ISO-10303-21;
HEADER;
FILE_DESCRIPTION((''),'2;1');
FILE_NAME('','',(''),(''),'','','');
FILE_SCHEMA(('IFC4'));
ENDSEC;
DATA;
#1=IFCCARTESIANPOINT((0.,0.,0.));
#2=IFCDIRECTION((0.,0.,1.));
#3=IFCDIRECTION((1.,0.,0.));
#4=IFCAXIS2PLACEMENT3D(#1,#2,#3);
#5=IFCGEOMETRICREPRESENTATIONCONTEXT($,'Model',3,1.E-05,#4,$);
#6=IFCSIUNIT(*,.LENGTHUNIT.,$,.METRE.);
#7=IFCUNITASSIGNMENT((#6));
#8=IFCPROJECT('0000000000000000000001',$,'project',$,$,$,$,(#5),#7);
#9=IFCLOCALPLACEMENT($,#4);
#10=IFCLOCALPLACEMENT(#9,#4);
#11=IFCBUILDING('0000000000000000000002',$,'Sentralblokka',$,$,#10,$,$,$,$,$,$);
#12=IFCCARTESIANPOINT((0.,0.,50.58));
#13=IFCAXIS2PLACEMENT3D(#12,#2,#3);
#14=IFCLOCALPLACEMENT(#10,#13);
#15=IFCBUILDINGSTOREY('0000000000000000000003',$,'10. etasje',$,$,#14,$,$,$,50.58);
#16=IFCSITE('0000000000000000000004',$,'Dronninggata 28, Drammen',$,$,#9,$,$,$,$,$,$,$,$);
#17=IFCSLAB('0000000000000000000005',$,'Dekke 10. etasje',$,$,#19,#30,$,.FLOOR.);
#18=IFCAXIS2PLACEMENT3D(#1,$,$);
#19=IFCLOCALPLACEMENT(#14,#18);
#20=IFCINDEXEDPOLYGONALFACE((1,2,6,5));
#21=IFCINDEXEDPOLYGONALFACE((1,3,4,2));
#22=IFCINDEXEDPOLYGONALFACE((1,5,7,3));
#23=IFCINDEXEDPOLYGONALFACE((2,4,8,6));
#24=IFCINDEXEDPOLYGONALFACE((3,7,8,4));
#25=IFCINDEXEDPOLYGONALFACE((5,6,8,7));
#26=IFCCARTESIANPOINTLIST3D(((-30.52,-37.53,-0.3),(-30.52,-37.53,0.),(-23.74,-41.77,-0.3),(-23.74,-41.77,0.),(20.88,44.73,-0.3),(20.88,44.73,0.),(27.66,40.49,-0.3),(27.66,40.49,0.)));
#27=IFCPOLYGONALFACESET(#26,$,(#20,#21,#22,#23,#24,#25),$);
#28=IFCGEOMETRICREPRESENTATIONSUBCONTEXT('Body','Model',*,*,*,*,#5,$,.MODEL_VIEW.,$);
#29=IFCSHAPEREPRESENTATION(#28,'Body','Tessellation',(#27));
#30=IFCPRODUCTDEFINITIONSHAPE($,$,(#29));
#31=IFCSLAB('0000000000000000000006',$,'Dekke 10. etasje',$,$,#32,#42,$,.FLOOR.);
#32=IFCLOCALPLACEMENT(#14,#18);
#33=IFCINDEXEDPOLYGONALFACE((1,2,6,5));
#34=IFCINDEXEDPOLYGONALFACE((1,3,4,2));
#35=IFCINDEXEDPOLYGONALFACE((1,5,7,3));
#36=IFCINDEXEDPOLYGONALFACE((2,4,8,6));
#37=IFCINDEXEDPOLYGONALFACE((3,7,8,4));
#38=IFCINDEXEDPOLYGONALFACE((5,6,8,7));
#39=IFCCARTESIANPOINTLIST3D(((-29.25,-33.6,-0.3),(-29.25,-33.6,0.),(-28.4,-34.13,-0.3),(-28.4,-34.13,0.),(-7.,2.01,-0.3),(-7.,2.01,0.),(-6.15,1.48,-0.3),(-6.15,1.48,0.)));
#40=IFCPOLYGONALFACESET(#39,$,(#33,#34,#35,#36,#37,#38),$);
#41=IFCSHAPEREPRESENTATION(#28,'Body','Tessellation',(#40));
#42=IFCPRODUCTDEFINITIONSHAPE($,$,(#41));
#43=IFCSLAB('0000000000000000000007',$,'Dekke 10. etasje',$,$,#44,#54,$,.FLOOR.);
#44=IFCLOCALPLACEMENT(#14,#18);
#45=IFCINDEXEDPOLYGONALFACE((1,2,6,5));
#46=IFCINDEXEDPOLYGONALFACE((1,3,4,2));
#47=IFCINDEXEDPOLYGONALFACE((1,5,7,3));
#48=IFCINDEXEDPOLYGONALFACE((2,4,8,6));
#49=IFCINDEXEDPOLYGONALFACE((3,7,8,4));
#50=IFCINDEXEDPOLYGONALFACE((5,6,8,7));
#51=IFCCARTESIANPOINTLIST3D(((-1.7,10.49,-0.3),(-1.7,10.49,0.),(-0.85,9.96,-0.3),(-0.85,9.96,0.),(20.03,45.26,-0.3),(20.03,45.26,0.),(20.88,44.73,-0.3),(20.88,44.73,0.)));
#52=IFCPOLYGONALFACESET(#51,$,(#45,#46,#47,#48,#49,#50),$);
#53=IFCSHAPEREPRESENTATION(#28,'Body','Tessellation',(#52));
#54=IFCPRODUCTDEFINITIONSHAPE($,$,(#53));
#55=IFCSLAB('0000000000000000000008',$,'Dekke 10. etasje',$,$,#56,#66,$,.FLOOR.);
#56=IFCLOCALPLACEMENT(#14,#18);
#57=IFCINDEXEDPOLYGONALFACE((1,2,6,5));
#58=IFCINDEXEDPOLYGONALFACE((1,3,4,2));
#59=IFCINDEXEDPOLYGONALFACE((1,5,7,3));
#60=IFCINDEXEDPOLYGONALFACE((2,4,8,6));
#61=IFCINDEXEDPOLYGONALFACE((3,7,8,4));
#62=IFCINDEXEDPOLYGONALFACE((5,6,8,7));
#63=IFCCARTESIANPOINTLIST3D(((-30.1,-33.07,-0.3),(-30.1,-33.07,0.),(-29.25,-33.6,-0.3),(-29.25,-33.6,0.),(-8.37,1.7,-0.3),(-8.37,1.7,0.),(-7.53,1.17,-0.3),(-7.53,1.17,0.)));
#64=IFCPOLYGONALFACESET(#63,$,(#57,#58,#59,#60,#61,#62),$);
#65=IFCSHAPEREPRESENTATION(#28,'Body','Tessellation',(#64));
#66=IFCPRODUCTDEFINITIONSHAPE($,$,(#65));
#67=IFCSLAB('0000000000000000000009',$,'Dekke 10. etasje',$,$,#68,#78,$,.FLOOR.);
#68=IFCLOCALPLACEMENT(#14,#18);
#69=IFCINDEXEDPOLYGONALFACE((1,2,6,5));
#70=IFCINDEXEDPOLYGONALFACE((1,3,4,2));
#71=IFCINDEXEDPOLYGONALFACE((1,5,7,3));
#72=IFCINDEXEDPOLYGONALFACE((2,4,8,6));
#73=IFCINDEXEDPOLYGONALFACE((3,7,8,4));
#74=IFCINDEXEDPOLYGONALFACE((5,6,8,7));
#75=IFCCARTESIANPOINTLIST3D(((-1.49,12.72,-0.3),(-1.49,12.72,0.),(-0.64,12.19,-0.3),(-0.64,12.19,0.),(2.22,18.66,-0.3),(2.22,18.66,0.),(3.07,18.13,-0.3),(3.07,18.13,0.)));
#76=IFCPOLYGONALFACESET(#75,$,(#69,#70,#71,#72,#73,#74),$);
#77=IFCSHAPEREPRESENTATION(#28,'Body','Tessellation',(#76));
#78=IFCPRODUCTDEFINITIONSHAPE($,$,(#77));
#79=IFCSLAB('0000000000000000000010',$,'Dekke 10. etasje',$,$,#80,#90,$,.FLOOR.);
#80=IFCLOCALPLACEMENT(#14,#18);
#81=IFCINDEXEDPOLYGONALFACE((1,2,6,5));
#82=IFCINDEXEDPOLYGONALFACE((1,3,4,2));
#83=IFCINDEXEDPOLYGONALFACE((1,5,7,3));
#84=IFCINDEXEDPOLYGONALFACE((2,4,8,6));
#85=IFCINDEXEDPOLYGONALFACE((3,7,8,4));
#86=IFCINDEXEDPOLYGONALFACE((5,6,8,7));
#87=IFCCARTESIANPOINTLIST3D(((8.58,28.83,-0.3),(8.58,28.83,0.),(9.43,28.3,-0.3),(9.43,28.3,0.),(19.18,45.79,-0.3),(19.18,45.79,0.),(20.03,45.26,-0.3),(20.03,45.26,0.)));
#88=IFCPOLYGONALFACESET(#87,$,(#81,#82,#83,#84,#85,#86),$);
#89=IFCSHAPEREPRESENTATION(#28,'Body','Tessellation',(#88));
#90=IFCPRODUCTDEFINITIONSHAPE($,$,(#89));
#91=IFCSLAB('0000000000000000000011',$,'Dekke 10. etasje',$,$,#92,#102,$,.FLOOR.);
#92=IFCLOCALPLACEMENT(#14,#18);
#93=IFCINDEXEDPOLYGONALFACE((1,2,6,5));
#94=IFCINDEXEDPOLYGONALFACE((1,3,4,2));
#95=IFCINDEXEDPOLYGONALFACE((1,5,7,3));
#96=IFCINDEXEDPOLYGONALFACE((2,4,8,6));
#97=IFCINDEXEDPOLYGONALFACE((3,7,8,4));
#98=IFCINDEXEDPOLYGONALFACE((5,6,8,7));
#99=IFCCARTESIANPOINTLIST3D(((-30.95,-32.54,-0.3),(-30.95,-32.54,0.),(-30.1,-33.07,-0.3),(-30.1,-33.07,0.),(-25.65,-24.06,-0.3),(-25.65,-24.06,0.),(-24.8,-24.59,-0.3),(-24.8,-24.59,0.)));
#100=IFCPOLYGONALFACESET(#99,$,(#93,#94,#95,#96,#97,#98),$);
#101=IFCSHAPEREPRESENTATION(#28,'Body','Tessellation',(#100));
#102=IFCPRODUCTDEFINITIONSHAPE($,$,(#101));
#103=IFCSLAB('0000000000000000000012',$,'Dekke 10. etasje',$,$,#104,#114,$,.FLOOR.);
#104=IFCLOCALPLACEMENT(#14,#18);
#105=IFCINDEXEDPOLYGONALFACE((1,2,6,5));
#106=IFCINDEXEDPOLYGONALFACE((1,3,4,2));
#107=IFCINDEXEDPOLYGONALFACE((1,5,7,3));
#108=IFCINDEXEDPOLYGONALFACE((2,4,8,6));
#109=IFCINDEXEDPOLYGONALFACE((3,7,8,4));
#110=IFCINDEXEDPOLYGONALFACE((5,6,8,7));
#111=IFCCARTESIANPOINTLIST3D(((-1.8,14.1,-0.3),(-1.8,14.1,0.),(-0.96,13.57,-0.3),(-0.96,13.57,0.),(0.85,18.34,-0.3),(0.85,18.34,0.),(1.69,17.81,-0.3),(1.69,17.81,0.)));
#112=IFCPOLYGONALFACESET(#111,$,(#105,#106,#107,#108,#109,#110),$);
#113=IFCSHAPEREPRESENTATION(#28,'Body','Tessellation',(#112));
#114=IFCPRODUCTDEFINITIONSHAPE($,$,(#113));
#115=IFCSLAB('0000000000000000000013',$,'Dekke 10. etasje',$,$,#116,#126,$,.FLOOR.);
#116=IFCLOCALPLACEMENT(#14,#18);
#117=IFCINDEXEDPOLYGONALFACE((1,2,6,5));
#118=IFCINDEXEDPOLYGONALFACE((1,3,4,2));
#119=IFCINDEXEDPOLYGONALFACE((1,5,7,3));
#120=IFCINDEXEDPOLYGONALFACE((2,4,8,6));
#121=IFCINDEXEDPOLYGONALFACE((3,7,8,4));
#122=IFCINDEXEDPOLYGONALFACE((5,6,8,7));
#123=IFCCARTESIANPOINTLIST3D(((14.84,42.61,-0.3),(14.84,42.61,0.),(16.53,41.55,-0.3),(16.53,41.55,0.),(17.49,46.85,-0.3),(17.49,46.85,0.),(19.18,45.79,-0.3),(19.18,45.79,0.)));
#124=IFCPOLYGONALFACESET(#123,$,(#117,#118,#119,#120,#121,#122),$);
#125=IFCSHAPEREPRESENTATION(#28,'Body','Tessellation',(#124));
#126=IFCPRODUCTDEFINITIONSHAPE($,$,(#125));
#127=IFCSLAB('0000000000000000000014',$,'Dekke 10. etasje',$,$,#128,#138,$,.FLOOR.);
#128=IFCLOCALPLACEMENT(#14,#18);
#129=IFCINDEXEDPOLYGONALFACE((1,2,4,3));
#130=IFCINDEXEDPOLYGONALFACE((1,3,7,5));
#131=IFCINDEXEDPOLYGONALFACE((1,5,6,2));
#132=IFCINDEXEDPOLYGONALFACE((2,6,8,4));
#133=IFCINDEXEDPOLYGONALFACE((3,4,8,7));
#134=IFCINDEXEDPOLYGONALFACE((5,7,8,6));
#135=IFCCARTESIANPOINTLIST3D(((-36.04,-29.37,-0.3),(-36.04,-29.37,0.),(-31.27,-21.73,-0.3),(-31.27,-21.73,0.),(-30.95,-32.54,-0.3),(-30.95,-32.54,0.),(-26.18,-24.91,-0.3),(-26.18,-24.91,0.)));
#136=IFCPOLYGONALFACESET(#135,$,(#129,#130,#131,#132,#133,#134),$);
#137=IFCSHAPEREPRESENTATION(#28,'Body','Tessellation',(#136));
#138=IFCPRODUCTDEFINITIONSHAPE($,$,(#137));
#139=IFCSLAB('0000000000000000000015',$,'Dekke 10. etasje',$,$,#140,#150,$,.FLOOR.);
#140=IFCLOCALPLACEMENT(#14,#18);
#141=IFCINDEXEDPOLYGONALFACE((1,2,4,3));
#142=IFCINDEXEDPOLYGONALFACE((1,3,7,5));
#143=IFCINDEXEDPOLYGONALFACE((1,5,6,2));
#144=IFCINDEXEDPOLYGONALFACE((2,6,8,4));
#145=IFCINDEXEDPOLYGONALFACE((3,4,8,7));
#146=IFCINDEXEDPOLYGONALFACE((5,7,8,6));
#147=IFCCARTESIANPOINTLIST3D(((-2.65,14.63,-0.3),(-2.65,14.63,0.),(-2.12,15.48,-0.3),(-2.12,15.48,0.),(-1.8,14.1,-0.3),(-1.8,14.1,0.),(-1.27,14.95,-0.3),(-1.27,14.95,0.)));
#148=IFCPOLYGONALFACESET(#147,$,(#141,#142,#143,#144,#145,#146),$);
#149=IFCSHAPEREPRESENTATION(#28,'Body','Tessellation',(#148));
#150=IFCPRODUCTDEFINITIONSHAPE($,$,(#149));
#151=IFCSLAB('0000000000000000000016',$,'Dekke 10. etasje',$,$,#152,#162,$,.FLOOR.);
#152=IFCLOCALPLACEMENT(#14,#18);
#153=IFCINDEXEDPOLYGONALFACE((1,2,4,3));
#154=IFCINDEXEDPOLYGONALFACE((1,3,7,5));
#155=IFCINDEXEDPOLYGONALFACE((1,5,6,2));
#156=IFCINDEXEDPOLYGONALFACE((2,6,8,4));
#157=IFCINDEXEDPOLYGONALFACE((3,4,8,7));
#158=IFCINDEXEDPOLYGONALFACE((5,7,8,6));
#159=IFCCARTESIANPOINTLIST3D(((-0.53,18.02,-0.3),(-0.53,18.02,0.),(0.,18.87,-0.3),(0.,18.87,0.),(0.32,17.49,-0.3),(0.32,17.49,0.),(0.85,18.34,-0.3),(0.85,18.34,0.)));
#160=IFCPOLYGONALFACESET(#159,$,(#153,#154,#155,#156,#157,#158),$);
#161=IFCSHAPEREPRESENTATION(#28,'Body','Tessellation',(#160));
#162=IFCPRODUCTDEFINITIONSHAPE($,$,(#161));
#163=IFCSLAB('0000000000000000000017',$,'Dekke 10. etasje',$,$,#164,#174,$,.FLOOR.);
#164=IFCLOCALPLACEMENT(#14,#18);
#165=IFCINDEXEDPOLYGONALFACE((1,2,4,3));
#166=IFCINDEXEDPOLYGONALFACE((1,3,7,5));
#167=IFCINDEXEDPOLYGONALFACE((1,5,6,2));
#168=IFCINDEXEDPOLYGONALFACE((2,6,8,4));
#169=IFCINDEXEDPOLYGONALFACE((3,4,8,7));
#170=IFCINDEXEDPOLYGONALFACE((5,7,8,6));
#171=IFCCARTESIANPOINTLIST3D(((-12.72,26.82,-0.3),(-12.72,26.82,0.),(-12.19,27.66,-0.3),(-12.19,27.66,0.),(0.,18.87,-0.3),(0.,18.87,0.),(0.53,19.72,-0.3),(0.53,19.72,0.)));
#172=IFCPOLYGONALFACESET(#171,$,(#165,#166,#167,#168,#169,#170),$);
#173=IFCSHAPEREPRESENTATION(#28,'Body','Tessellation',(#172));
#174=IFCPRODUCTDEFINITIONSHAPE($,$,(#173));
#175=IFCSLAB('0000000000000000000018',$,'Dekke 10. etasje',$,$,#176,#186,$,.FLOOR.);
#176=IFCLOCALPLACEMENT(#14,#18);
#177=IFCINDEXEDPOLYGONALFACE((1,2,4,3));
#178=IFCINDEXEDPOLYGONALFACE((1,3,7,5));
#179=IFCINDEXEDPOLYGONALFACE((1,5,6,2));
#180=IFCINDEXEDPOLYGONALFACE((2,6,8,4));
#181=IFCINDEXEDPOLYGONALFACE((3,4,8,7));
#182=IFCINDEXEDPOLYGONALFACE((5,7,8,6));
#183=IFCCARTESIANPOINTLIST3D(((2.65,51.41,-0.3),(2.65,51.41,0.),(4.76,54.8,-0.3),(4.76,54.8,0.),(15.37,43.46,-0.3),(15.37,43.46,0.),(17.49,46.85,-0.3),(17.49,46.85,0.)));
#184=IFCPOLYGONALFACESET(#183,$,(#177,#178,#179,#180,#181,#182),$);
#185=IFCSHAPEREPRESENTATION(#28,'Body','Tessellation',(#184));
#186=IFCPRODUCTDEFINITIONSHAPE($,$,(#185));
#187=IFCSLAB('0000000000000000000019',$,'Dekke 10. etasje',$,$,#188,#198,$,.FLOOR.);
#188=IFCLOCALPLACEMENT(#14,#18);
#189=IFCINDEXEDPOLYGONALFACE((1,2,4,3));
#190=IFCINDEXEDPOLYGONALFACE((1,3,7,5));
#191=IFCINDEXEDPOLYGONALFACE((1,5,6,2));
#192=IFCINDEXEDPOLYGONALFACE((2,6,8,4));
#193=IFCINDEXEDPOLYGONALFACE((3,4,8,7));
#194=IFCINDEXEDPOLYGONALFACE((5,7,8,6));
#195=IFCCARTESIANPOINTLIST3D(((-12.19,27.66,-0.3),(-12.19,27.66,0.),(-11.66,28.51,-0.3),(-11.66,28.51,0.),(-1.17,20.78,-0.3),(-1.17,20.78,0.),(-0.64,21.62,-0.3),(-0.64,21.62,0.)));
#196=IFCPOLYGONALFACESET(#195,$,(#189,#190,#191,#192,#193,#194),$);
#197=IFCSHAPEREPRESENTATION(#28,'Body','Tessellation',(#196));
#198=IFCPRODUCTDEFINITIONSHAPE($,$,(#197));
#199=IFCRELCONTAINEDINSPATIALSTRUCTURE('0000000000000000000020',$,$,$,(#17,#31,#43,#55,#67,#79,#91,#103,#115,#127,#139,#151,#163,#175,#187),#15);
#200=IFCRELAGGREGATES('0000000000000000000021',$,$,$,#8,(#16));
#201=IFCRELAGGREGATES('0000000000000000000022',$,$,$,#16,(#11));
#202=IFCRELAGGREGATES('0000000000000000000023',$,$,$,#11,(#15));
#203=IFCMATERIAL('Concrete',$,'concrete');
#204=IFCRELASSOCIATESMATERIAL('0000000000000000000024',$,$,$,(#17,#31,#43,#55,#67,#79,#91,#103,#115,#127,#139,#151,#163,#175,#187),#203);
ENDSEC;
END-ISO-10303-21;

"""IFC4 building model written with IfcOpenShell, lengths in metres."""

from ifc_helpers import new_model, si_unit, frame, origin_with_axes, place, context, subcontext, project, spatial, polyline, outline, extrude, material, element, save


model = new_model("IFC4")

# Units and contexts
model_context = context("Model", 3, precision=1e-05, world=origin_with_axes())
body_context = subcontext(model_context, "Body", "Model", "MODEL_VIEW")
ifc_project = project(units=[si_unit("LENGTHUNIT", "METRE")], contexts=[model_context])

# Site, building, storey
site_placement = place(None, origin_with_axes())
site = spatial("IfcSite", under=ifc_project, at=site_placement, Name="Dronninggata 28, Drammen")
building_placement = place(site_placement, origin_with_axes())
building = spatial("IfcBuilding", under=site, at=building_placement, Name="Sentralblokka")
storey_placement = place(building_placement, frame((0.0, 0.0, 50.58), z_axis=(0.0, 0.0, 1.0), x_axis=(1.0, 0.0, 0.0)))
storey = spatial("IfcBuildingStorey", under=building, at=storey_placement, Name="10. etasje", Elevation=50.58)

# Slabs
ifc_material = material(Name="Concrete", Category="concrete")
slab_1_placement = place(storey_placement, frame((0.0, 0.0, -50.58), z_axis=(0.0, 0.0, 1.0), x_axis=(1.0, 0.0, 0.0)))
element("IfcSlab", 1, at=slab_1_placement, inside=storey, material=ifc_material, Name="Dekke 10. etasje", PredefinedType="FLOOR", context=body_context, shape_type="SweptSolid", body=[
    extrude(outline(polyline([(-23.74, -41.77), (27.66, 40.49), (20.88, 44.73), (-30.52, -37.53), (-23.74, -41.77)])), frame((0.0, 0.0, 50.28)), (0.0, 0.0, 1.0), 0.3),
])
slab_2_placement = place(storey_placement, frame((0.0, 0.0, -50.58), z_axis=(0.0, 0.0, 1.0), x_axis=(1.0, 0.0, 0.0)))
element("IfcSlab", 2, at=slab_2_placement, inside=storey, material=ifc_material, Name="Dekke 10. etasje", PredefinedType="FLOOR", context=body_context, shape_type="SweptSolid", body=[
    extrude(outline(polyline([(-28.4, -34.13), (-6.15, 1.48), (-7.0, 2.01), (-29.25, -33.6), (-28.4, -34.13)])), frame((0.0, 0.0, 50.28)), (0.0, 0.0, 1.0), 0.3),
])
slab_3_placement = place(storey_placement, frame((0.0, 0.0, -50.58), z_axis=(0.0, 0.0, 1.0), x_axis=(1.0, 0.0, 0.0)))
element("IfcSlab", 3, at=slab_3_placement, inside=storey, material=ifc_material, Name="Dekke 10. etasje", PredefinedType="FLOOR", context=body_context, shape_type="SweptSolid", body=[
    extrude(outline(polyline([(-0.85, 9.96), (20.88, 44.73), (20.03, 45.26), (-1.7, 10.49), (-0.85, 9.96)])), frame((0.0, 0.0, 50.28)), (0.0, 0.0, 1.0), 0.3),
])
slab_4_placement = place(storey_placement, frame((0.0, 0.0, -50.58), z_axis=(0.0, 0.0, 1.0), x_axis=(1.0, 0.0, 0.0)))
element("IfcSlab", 4, at=slab_4_placement, inside=storey, material=ifc_material, Name="Dekke 10. etasje", PredefinedType="FLOOR", context=body_context, shape_type="SweptSolid", body=[
    extrude(outline(polyline([(-29.25, -33.6), (-7.53, 1.17), (-8.37, 1.7), (-30.1, -33.07), (-29.25, -33.6)])), frame((0.0, 0.0, 50.28)), (0.0, 0.0, 1.0), 0.3),
])
slab_5_placement = place(storey_placement, frame((0.0, 0.0, -50.58), z_axis=(0.0, 0.0, 1.0), x_axis=(1.0, 0.0, 0.0)))
element("IfcSlab", 5, at=slab_5_placement, inside=storey, material=ifc_material, Name="Dekke 10. etasje", PredefinedType="FLOOR", context=body_context, shape_type="SweptSolid", body=[
    extrude(outline(polyline([(-0.64, 12.19), (3.07, 18.13), (2.22, 18.66), (-1.49, 12.72), (-0.64, 12.19)])), frame((0.0, 0.0, 50.28)), (0.0, 0.0, 1.0), 0.3),
])
slab_6_placement = place(storey_placement, frame((0.0, 0.0, -50.58), z_axis=(0.0, 0.0, 1.0), x_axis=(1.0, 0.0, 0.0)))
element("IfcSlab", 6, at=slab_6_placement, inside=storey, material=ifc_material, Name="Dekke 10. etasje", PredefinedType="FLOOR", context=body_context, shape_type="SweptSolid", body=[
    extrude(outline(polyline([(9.43, 28.3), (20.03, 45.26), (19.18, 45.79), (8.58, 28.83), (9.43, 28.3)])), frame((0.0, 0.0, 50.28)), (0.0, 0.0, 1.0), 0.3),
])
slab_7_placement = place(storey_placement, frame((0.0, 0.0, -50.58), z_axis=(0.0, 0.0, 1.0), x_axis=(1.0, 0.0, 0.0)))
element("IfcSlab", 7, at=slab_7_placement, inside=storey, material=ifc_material, Name="Dekke 10. etasje", PredefinedType="FLOOR", context=body_context, shape_type="SweptSolid", body=[
    extrude(outline(polyline([(-30.1, -33.07), (-24.8, -24.59), (-25.65, -24.06), (-30.95, -32.54), (-30.1, -33.07)])), frame((0.0, 0.0, 50.28)), (0.0, 0.0, 1.0), 0.3),
])
slab_8_placement = place(storey_placement, frame((0.0, 0.0, -50.58), z_axis=(0.0, 0.0, 1.0), x_axis=(1.0, 0.0, 0.0)))
element("IfcSlab", 8, at=slab_8_placement, inside=storey, material=ifc_material, Name="Dekke 10. etasje", PredefinedType="FLOOR", context=body_context, shape_type="SweptSolid", body=[
    extrude(outline(polyline([(-0.96, 13.57), (1.69, 17.81), (0.85, 18.34), (-1.8, 14.1), (-0.96, 13.57)])), frame((0.0, 0.0, 50.28)), (0.0, 0.0, 1.0), 0.3),
])
slab_9_placement = place(storey_placement, frame((0.0, 0.0, -50.58), z_axis=(0.0, 0.0, 1.0), x_axis=(1.0, 0.0, 0.0)))
element("IfcSlab", 9, at=slab_9_placement, inside=storey, material=ifc_material, Name="Dekke 10. etasje", PredefinedType="FLOOR", context=body_context, shape_type="SweptSolid", body=[
    extrude(outline(polyline([(16.53, 41.55), (19.18, 45.79), (17.49, 46.85), (14.84, 42.61), (16.53, 41.55)])), frame((0.0, 0.0, 50.28)), (0.0, 0.0, 1.0), 0.3),
])
slab_10_placement = place(storey_placement, frame((0.0, 0.0, -50.58), z_axis=(0.0, 0.0, 1.0), x_axis=(1.0, 0.0, 0.0)))
element("IfcSlab", 10, at=slab_10_placement, inside=storey, material=ifc_material, Name="Dekke 10. etasje", PredefinedType="FLOOR", context=body_context, shape_type="SweptSolid", body=[
    extrude(outline(polyline([(-30.95, -32.54), (-26.18, -24.91), (-31.27, -21.73), (-36.04, -29.37), (-30.95, -32.54)])), frame((0.0, 0.0, 50.28)), (0.0, 0.0, 1.0), 0.3),
])
slab_11_placement = place(storey_placement, frame((0.0, 0.0, -50.58), z_axis=(0.0, 0.0, 1.0), x_axis=(1.0, 0.0, 0.0)))
element("IfcSlab", 11, at=slab_11_placement, inside=storey, material=ifc_material, Name="Dekke 10. etasje", PredefinedType="FLOOR", context=body_context, shape_type="SweptSolid", body=[
    extrude(outline(polyline([(-1.8, 14.1), (-1.27, 14.95), (-2.12, 15.48), (-2.65, 14.63), (-1.8, 14.1)])), frame((0.0, 0.0, 50.28)), (0.0, 0.0, 1.0), 0.3),
])
slab_12_placement = place(storey_placement, frame((0.0, 0.0, -50.58), z_axis=(0.0, 0.0, 1.0), x_axis=(1.0, 0.0, 0.0)))
element("IfcSlab", 12, at=slab_12_placement, inside=storey, material=ifc_material, Name="Dekke 10. etasje", PredefinedType="FLOOR", context=body_context, shape_type="SweptSolid", body=[
    extrude(outline(polyline([(0.32, 17.49), (0.85, 18.34), (0.0, 18.87), (-0.53, 18.02), (0.32, 17.49)])), frame((0.0, 0.0, 50.28)), (0.0, 0.0, 1.0), 0.3),
])
slab_13_placement = place(storey_placement, frame((0.0, 0.0, -50.58), z_axis=(0.0, 0.0, 1.0), x_axis=(1.0, 0.0, 0.0)))
element("IfcSlab", 13, at=slab_13_placement, inside=storey, material=ifc_material, Name="Dekke 10. etasje", PredefinedType="FLOOR", context=body_context, shape_type="SweptSolid", body=[
    extrude(outline(polyline([(0.0, 18.87), (0.53, 19.72), (-12.19, 27.66), (-12.72, 26.82), (0.0, 18.87)])), frame((0.0, 0.0, 50.28)), (0.0, 0.0, 1.0), 0.3),
])
slab_14_placement = place(storey_placement, frame((0.0, 0.0, -50.58), z_axis=(0.0, 0.0, 1.0), x_axis=(1.0, 0.0, 0.0)))
element("IfcSlab", 14, at=slab_14_placement, inside=storey, material=ifc_material, Name="Dekke 10. etasje", PredefinedType="FLOOR", context=body_context, shape_type="SweptSolid", body=[
    extrude(outline(polyline([(15.37, 43.46), (17.49, 46.85), (4.76, 54.8), (2.65, 51.41), (15.37, 43.46)])), frame((0.0, 0.0, 50.28)), (0.0, 0.0, 1.0), 0.3),
])
slab_15_placement = place(storey_placement, frame((0.0, 0.0, -50.58), z_axis=(0.0, 0.0, 1.0), x_axis=(1.0, 0.0, 0.0)))
element("IfcSlab", 15, at=slab_15_placement, inside=storey, material=ifc_material, Name="Dekke 10. etasje", PredefinedType="FLOOR", context=body_context, shape_type="SweptSolid", body=[
    extrude(outline(polyline([(-1.17, 20.78), (-0.64, 21.62), (-11.66, 28.51), (-12.19, 27.66), (-1.17, 20.78)])), frame((0.0, 0.0, 50.28)), (0.0, 0.0, 1.0), 0.3),
])

save(model, "model.ifc")
